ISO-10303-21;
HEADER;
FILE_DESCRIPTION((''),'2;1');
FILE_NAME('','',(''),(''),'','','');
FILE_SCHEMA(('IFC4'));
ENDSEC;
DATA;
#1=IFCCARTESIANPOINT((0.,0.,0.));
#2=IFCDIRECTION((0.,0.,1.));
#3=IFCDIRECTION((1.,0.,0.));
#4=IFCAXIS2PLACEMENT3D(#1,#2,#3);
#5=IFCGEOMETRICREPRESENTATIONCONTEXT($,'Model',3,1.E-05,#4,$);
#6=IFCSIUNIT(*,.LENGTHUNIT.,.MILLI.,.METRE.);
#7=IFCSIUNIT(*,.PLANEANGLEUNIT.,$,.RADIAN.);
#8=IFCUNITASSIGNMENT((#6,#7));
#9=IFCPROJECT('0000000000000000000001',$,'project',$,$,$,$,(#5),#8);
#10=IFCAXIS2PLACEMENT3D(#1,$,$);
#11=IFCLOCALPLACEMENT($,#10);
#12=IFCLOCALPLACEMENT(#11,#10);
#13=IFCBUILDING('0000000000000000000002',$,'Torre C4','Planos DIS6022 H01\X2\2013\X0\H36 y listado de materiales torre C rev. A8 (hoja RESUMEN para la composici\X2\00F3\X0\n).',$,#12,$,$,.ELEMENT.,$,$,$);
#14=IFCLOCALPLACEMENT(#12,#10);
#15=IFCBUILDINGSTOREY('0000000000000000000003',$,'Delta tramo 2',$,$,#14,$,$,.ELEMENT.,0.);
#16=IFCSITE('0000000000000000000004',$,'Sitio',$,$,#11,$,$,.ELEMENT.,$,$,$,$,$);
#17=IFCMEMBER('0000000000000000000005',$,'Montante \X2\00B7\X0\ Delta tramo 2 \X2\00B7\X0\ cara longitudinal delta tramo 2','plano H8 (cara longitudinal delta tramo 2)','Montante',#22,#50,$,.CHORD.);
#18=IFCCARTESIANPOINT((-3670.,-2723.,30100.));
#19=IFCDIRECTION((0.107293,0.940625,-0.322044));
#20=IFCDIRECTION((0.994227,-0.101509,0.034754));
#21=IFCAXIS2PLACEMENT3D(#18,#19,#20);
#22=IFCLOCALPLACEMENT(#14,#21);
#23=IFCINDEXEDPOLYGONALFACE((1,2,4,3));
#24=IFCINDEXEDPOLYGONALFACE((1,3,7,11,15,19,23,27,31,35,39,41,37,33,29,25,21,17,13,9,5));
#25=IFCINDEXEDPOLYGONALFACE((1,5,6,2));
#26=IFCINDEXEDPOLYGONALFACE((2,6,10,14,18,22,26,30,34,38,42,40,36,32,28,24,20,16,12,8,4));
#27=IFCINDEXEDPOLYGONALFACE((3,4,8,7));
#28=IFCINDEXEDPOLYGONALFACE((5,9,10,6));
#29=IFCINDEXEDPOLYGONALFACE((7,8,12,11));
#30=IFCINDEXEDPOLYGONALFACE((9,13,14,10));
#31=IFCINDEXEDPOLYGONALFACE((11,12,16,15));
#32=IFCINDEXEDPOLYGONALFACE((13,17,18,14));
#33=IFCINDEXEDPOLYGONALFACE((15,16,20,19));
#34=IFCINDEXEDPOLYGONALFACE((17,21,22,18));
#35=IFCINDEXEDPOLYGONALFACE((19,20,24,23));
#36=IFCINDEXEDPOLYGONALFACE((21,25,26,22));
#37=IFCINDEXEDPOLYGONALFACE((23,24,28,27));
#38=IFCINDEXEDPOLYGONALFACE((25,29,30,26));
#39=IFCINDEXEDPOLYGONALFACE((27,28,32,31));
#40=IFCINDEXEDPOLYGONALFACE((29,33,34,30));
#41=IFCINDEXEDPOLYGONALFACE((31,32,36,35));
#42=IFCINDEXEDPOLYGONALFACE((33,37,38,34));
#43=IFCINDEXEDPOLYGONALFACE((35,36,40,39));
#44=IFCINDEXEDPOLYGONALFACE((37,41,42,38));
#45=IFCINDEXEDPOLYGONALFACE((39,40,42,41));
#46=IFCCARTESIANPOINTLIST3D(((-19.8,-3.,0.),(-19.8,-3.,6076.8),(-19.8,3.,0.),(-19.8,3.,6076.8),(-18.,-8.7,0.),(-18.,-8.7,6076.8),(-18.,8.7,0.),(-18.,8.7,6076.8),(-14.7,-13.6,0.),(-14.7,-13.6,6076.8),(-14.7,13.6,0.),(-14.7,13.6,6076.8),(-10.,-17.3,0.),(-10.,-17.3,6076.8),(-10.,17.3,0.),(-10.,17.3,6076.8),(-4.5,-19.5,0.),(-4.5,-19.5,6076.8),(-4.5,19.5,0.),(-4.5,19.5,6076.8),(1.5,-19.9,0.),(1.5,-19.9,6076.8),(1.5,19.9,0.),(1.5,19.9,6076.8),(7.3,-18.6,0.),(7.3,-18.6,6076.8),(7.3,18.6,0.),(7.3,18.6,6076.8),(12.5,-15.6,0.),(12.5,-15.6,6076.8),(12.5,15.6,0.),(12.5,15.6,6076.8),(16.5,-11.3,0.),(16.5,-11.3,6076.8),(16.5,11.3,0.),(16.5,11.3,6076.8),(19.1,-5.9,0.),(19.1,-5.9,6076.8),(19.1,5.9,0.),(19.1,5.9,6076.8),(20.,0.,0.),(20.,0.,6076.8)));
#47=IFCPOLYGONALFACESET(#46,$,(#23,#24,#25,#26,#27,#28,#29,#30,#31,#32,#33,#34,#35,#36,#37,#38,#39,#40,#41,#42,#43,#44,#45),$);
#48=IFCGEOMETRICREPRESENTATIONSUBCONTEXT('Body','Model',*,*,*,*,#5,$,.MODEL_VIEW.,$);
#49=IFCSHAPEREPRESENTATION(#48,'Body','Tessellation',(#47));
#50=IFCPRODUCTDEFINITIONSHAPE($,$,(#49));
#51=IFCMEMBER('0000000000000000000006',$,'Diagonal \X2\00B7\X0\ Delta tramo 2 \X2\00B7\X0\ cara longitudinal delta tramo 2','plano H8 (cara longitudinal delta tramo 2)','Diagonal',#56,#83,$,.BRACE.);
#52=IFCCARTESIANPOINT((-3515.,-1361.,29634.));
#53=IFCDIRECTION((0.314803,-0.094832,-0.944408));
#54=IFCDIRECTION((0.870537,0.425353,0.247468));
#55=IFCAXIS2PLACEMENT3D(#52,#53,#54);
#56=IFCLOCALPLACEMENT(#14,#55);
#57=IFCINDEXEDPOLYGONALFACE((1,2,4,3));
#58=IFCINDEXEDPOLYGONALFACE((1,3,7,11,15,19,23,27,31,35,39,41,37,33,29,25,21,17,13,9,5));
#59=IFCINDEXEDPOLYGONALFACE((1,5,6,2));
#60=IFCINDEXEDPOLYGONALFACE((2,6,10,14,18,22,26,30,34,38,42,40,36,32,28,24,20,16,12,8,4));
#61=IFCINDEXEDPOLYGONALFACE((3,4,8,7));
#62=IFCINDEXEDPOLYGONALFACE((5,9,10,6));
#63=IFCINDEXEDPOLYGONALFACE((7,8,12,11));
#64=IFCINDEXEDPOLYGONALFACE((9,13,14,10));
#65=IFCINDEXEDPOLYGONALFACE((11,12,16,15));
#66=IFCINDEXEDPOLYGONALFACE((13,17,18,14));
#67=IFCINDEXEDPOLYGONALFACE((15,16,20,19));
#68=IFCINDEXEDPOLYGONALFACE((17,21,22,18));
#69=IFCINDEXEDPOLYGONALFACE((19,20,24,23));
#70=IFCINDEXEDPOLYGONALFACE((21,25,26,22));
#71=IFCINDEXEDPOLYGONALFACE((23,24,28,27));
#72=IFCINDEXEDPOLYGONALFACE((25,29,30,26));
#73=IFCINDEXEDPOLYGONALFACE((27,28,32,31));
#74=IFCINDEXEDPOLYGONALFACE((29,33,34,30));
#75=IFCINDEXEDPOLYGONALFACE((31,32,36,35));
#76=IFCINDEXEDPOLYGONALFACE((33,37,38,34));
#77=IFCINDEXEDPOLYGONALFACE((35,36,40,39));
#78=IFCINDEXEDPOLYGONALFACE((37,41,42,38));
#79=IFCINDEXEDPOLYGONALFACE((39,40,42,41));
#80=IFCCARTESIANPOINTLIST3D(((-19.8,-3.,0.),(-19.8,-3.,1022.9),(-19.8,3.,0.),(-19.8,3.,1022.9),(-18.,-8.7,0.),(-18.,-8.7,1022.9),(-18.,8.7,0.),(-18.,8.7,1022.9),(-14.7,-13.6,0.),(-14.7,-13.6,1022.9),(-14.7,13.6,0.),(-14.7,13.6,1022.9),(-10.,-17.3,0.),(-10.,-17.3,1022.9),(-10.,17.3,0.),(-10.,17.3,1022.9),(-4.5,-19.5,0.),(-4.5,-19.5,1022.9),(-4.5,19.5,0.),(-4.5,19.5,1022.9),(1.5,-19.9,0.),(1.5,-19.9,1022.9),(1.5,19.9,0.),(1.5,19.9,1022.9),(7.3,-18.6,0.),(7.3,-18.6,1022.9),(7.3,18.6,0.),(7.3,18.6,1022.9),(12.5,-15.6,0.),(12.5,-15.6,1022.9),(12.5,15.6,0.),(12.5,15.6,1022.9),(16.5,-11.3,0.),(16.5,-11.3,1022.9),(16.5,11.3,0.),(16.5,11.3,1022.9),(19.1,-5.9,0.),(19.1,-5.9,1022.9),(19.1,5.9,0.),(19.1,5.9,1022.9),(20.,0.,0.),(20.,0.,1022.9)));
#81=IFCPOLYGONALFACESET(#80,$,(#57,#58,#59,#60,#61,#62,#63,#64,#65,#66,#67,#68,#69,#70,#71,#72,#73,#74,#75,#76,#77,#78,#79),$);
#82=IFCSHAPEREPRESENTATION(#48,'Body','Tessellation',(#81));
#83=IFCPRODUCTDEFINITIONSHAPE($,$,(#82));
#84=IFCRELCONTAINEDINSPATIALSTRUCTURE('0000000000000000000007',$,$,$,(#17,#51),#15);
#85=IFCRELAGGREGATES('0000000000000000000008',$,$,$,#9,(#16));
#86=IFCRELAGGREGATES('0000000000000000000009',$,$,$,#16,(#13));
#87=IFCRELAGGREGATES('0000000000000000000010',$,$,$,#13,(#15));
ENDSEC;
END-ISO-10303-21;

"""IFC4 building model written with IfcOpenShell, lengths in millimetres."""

from ifc_helpers import new_model, si_unit, frame, origin, origin_with_axes, place, context, subcontext, project, spatial, circle, extrude, element, save


model = new_model("IFC4")

# Units and contexts
model_context = context("Model", 3, precision=1e-05, world=origin_with_axes())
body_context = subcontext(model_context, "Body", "Model", "MODEL_VIEW")
ifc_project = project(units=[si_unit("LENGTHUNIT", "METRE", prefix="MILLI"), si_unit("PLANEANGLEUNIT", "RADIAN")], contexts=[model_context])

# Site, building, storey
site_placement = place(None, origin())
site = spatial("IfcSite", under=ifc_project, at=site_placement, Name="Sitio", CompositionType="ELEMENT")
building_placement = place(site_placement, origin())
building = spatial("IfcBuilding", under=site, at=building_placement, Name="Torre C4", Description="Planos DIS6022 H01–H36 y listado de materiales torre C rev. A8 (hoja RESUMEN para la composición).", CompositionType="ELEMENT")
storey_placement = place(building_placement, origin())
storey = spatial("IfcBuildingStorey", under=building, at=storey_placement, Name="Delta tramo 2", CompositionType="ELEMENT", Elevation=0.0)

# Members
member_1_placement = place(storey_placement, frame((-3670.0, -2723.0, 30100.0), z_axis=(0.107293, 0.940625, -0.322044), x_axis=(0.994227, -0.101509, 0.034754)))
element("IfcMember", 1, at=member_1_placement, inside=storey, Name="Montante · Delta tramo 2 · cara longitudinal delta tramo 2", Description="plano H8 (cara longitudinal delta tramo 2)", ObjectType="Montante", PredefinedType="CHORD", context=body_context, shape_type="SweptSolid", body=[
    extrude(circle(Radius=20.0), None, (0.0, 0.0, 1.0), 6076.8),
])
member_2_placement = place(storey_placement, frame((-3515.0, -1361.0, 29634.0), z_axis=(0.314803, -0.094832, -0.944408), x_axis=(0.870537, 0.425353, 0.247468)))
element("IfcMember", 2, at=member_2_placement, inside=storey, Name="Diagonal · Delta tramo 2 · cara longitudinal delta tramo 2", Description="plano H8 (cara longitudinal delta tramo 2)", ObjectType="Diagonal", PredefinedType="BRACE", context=body_context, shape_type="SweptSolid", body=[
    extrude(circle(Radius=20.0), None, (0.0, 0.0, 1.0), 1022.9),
])

save(model, "model.ifc")
